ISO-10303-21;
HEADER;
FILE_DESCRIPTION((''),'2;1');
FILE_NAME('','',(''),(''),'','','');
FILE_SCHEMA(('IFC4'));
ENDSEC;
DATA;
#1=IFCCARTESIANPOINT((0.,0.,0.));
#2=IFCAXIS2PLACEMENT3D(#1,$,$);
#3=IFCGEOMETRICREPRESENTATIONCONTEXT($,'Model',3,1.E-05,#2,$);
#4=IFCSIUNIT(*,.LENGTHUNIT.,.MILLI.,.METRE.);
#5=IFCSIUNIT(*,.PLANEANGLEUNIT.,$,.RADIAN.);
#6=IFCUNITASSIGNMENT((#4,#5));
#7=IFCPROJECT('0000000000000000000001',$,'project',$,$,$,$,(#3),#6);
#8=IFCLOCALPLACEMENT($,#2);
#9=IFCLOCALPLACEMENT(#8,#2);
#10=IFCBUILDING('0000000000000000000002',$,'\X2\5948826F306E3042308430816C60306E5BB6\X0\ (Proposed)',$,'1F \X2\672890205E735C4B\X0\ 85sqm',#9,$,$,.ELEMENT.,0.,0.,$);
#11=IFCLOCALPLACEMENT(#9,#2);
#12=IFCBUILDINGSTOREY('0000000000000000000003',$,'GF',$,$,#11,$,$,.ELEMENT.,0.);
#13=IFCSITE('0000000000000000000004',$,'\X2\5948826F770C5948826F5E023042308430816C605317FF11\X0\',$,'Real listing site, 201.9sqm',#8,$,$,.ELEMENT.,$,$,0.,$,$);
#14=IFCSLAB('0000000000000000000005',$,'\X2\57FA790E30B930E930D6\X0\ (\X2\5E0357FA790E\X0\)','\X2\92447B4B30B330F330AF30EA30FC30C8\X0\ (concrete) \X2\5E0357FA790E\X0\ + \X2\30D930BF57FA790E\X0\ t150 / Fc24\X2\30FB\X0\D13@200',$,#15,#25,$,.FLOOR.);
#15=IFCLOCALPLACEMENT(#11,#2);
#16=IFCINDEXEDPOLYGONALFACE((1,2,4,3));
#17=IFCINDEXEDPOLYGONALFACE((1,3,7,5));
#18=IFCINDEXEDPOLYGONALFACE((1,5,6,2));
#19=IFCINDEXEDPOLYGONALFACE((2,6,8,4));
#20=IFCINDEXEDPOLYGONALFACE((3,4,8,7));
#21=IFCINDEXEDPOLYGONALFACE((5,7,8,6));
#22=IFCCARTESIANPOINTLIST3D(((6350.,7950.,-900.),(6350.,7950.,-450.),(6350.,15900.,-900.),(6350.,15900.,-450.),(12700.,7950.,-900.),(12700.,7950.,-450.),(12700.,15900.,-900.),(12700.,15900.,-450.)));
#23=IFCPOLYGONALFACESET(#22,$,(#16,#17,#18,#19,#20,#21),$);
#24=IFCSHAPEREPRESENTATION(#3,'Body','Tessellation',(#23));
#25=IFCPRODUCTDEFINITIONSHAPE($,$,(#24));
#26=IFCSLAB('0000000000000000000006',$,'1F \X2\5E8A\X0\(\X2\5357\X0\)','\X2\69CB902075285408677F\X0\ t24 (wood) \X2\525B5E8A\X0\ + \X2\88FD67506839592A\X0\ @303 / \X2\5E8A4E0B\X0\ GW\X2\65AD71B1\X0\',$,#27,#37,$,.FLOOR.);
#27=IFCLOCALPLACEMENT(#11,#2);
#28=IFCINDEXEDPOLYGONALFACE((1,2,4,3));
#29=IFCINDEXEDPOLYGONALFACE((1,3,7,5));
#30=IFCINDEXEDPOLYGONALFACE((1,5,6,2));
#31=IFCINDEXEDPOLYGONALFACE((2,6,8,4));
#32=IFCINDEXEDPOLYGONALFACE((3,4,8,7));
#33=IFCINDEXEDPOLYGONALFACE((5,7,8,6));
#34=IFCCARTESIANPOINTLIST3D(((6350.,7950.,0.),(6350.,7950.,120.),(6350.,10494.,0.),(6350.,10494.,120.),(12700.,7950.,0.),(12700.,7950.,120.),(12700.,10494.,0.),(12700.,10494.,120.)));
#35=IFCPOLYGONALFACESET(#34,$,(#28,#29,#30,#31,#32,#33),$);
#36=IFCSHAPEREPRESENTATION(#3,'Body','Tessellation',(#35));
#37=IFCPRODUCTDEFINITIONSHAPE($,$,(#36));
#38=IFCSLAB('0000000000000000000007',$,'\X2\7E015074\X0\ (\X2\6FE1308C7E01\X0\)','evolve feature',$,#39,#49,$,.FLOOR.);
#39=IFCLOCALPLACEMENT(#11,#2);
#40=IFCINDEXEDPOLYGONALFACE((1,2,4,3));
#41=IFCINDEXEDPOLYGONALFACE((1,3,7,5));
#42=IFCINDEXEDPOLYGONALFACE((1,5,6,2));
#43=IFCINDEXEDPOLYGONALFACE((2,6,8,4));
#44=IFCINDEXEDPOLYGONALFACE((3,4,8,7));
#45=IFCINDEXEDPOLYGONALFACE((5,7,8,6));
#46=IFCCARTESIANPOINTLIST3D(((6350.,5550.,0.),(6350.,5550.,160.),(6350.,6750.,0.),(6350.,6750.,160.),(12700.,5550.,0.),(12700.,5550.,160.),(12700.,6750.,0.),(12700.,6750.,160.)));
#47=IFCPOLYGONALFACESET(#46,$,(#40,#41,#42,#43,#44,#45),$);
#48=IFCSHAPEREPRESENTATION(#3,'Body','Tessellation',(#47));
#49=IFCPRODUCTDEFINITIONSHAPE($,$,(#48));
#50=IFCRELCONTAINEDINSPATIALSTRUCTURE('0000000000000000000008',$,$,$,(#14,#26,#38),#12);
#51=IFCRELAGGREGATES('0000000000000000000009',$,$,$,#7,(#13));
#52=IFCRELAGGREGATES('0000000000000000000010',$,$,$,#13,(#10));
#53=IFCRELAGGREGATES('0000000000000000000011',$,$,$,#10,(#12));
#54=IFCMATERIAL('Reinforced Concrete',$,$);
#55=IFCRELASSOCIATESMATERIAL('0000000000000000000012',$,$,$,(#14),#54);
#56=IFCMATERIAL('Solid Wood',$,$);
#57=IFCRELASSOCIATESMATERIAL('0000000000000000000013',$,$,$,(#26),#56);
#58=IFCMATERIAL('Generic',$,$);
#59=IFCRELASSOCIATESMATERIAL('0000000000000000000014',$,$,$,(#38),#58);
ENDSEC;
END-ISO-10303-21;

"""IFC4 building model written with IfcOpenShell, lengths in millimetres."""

from ifc_helpers import new_model, si_unit, frame, frame_2d, origin, place, context, project, spatial, rectangle, extrude, material, element, save


model = new_model("IFC4")

# Units and contexts
model_context = context("Model", 3, precision=1e-05, world=origin())
ifc_project = project(units=[si_unit("LENGTHUNIT", "METRE", prefix="MILLI"), si_unit("PLANEANGLEUNIT", "RADIAN")], contexts=[model_context])

# Site, building, storey
site_placement = place(None, origin())
site = spatial("IfcSite", under=ifc_project, at=site_placement, Name="奈良県奈良市あやめ池北１", ObjectType="Real listing site, 201.9sqm", CompositionType="ELEMENT", RefElevation=0.0)
building_placement = place(site_placement, origin())
building = spatial("IfcBuilding", under=site, at=building_placement, Name="奈良のあやめ池の家 (Proposed)", ObjectType="1F 木造平屋 85sqm", CompositionType="ELEMENT", ElevationOfRefHeight=0.0, ElevationOfTerrain=0.0)
storey_placement = place(building_placement, origin())
storey = spatial("IfcBuildingStorey", under=building, at=storey_placement, Name="GF", CompositionType="ELEMENT", Elevation=0.0)

# Slabs
ifc_material_1 = material(Name="Reinforced Concrete")
slab_1_placement = place(storey_placement, frame((3175.0, 3975.0, -450.0)))
element("IfcSlab", 1, at=slab_1_placement, inside=storey, material=ifc_material_1, Name="基礎スラブ (布基礎)", Description="鉄筋コンクリート (concrete) 布基礎 + ベタ基礎 t150 / Fc24・D13@200", PredefinedType="FLOOR", context=model_context, shape_type="SweptSolid", body=[
    extrude(rectangle(XDim=6350.0, YDim=7950.0, at=frame_2d((3175.0, 3975.0))), frame((3175.0, 3975.0, -450.0)), (0.0, 0.0, 1.0), 450.0),
])
ifc_material_2 = material(Name="Solid Wood")
slab_2_placement = place(storey_placement, frame((3175.0, 3975.0, 0.0)))
element("IfcSlab", 2, at=slab_2_placement, inside=storey, material=ifc_material_2, Name="1F 床(南)", Description="構造用合板 t24 (wood) 剛床 + 製材根太 @303 / 床下 GW断熱", PredefinedType="FLOOR", context=model_context, shape_type="SweptSolid", body=[
    extrude(rectangle(XDim=6350.0, YDim=2544.0, at=frame_2d((3175.0, 1272.0))), frame((3175.0, 3975.0, 0.0)), (0.0, 0.0, 1.0), 120.0),
])
ifc_material_3 = material(Name="Generic")
slab_3_placement = place(storey_placement, frame((3175.0, 2775.0, 0.0)))
element("IfcSlab", 3, at=slab_3_placement, inside=storey, material=ifc_material_3, Name="縁側 (濡れ縁)", Description="evolve feature", PredefinedType="FLOOR", context=model_context, shape_type="SweptSolid", body=[
    extrude(rectangle(XDim=6350.0, YDim=1200.0, at=frame_2d((3175.0, 600.0))), frame((3175.0, 2775.0, 0.0)), (0.0, 0.0, 1.0), 160.0),
])

save(model, "model.ifc")
